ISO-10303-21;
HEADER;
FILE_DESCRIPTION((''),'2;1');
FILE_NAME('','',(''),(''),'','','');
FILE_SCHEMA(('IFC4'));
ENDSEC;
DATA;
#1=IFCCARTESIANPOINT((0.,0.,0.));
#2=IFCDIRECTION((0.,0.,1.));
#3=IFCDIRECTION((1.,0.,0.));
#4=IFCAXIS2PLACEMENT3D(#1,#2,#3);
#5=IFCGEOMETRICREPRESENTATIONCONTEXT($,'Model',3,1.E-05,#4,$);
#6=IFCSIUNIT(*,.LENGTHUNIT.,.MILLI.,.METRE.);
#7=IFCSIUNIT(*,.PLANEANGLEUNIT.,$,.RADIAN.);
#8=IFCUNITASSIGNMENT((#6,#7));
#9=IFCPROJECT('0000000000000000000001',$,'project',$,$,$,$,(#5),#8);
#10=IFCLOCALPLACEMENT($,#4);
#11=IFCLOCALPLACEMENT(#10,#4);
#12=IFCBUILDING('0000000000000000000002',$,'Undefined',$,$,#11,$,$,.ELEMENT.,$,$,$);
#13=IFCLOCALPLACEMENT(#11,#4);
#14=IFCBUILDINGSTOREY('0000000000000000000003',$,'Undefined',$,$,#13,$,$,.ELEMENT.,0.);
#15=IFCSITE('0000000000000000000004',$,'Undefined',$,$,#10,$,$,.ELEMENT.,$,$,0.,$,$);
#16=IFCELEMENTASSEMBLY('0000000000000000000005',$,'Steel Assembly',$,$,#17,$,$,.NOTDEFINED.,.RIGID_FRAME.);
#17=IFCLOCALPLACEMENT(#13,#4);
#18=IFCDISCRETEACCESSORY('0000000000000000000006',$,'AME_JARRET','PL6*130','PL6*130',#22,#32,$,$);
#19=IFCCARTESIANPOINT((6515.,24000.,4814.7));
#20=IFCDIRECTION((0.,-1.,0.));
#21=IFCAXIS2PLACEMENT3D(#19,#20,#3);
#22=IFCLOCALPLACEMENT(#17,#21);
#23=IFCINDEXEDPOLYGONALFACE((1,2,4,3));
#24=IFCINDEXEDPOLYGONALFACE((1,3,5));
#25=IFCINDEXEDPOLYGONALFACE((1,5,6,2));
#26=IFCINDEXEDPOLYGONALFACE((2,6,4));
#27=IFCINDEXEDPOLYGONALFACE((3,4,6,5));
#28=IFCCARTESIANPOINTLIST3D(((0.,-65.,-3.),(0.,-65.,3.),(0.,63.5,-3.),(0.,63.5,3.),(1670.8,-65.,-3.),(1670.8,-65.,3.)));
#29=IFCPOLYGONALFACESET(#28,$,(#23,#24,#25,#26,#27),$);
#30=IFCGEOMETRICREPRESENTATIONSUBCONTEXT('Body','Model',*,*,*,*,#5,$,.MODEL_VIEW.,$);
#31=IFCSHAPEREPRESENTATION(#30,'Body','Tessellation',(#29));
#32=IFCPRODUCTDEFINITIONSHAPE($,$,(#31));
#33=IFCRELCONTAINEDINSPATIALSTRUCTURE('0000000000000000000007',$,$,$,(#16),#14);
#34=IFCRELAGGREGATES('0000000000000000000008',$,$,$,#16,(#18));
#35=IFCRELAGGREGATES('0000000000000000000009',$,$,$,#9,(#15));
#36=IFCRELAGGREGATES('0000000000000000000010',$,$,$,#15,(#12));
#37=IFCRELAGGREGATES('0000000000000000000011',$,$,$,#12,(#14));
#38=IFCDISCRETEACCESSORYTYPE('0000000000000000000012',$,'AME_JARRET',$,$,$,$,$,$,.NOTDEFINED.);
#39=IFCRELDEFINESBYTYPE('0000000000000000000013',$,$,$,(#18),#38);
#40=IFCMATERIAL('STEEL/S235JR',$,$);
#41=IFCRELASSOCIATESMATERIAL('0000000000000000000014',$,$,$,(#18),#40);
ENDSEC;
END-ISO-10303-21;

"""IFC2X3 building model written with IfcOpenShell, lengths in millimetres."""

from ifc_helpers import new_model, si_unit, frame, origin_with_axes, place, context, subcontext, project, spatial, polyline, outline, extrude, clip, halfspace, material, type_object, element, aggregate, save


model = new_model("IFC2X3")

# Units and contexts
model_context = context("Model", 3, precision=1e-05, world=origin_with_axes())
body_context = subcontext(model_context, "Body", "Model", "MODEL_VIEW")
ifc_project = project(units=[si_unit("LENGTHUNIT", "METRE", prefix="MILLI"), si_unit("PLANEANGLEUNIT", "RADIAN")], contexts=[model_context])

# Site, building, storey
site_placement = place(None, origin_with_axes())
site = spatial("IfcSite", under=ifc_project, at=site_placement, Name="Undefined", CompositionType="ELEMENT", RefElevation=0.0)
building_placement = place(site_placement, origin_with_axes())
building = spatial("IfcBuilding", under=site, at=building_placement, Name="Undefined", CompositionType="ELEMENT")
storey_placement = place(building_placement, origin_with_axes())
storey = spatial("IfcBuildingStorey", under=building, at=storey_placement, Name="Undefined", CompositionType="ELEMENT", Elevation=0.0)

# Shared definitions
ifc_material_1 = material(Name="STEEL/S235JR")

# Element assembly
assembly_1_placement = place(storey_placement, origin_with_axes())
assembly_1 = element("IfcElementAssembly", 1, at=assembly_1_placement, inside=storey, Name="Steel Assembly", AssemblyPlace="NOTDEFINED", PredefinedType="RIGID_FRAME")

# Discrete accessory
discrete_accessory_type_1 = type_object("IfcDiscreteAccessoryType", Name="AME_JARRET")
discrete_accessory_1_placement = place(assembly_1_placement, frame((6515.0, 24000.0, 4814.7), z_axis=(0.0, -1.0, 0.0), x_axis=(1.0, 0.0, 0.0)))
discrete_accessory_1 = element("IfcDiscreteAccessory", 2, at=discrete_accessory_1_placement, type_object=discrete_accessory_type_1, material=ifc_material_1, Name="AME_JARRET", Description="PL6*130", ObjectType="PL6*130", context=body_context, shape_type="Clipping", body=[
    clip(clip(extrude(outline(polyline([(0.0, -65.0), (0.0, 63.5), (1670.8, -65.0), (0.0, -65.0)])), frame((0.0, 0.0, -3.0), z_axis=(0.0, 0.0, 1.0), x_axis=(1.0, 0.0, 0.0)), (0.0, 0.0, 1.0), 6.0), halfspace(frame((1670.8, -65.0, -3.0), z_axis=(0.076696, 0.997054, 0.0), x_axis=(0.0, 0.0, 1.0)), False)), halfspace(frame((0.0, -65.0, -3.0), z_axis=(-1.0, 0.0, 0.0), x_axis=(0.0, 1.0, 0.0)), False)),
])

aggregate(assembly_1, [discrete_accessory_1])

save(model, "model.ifc")
